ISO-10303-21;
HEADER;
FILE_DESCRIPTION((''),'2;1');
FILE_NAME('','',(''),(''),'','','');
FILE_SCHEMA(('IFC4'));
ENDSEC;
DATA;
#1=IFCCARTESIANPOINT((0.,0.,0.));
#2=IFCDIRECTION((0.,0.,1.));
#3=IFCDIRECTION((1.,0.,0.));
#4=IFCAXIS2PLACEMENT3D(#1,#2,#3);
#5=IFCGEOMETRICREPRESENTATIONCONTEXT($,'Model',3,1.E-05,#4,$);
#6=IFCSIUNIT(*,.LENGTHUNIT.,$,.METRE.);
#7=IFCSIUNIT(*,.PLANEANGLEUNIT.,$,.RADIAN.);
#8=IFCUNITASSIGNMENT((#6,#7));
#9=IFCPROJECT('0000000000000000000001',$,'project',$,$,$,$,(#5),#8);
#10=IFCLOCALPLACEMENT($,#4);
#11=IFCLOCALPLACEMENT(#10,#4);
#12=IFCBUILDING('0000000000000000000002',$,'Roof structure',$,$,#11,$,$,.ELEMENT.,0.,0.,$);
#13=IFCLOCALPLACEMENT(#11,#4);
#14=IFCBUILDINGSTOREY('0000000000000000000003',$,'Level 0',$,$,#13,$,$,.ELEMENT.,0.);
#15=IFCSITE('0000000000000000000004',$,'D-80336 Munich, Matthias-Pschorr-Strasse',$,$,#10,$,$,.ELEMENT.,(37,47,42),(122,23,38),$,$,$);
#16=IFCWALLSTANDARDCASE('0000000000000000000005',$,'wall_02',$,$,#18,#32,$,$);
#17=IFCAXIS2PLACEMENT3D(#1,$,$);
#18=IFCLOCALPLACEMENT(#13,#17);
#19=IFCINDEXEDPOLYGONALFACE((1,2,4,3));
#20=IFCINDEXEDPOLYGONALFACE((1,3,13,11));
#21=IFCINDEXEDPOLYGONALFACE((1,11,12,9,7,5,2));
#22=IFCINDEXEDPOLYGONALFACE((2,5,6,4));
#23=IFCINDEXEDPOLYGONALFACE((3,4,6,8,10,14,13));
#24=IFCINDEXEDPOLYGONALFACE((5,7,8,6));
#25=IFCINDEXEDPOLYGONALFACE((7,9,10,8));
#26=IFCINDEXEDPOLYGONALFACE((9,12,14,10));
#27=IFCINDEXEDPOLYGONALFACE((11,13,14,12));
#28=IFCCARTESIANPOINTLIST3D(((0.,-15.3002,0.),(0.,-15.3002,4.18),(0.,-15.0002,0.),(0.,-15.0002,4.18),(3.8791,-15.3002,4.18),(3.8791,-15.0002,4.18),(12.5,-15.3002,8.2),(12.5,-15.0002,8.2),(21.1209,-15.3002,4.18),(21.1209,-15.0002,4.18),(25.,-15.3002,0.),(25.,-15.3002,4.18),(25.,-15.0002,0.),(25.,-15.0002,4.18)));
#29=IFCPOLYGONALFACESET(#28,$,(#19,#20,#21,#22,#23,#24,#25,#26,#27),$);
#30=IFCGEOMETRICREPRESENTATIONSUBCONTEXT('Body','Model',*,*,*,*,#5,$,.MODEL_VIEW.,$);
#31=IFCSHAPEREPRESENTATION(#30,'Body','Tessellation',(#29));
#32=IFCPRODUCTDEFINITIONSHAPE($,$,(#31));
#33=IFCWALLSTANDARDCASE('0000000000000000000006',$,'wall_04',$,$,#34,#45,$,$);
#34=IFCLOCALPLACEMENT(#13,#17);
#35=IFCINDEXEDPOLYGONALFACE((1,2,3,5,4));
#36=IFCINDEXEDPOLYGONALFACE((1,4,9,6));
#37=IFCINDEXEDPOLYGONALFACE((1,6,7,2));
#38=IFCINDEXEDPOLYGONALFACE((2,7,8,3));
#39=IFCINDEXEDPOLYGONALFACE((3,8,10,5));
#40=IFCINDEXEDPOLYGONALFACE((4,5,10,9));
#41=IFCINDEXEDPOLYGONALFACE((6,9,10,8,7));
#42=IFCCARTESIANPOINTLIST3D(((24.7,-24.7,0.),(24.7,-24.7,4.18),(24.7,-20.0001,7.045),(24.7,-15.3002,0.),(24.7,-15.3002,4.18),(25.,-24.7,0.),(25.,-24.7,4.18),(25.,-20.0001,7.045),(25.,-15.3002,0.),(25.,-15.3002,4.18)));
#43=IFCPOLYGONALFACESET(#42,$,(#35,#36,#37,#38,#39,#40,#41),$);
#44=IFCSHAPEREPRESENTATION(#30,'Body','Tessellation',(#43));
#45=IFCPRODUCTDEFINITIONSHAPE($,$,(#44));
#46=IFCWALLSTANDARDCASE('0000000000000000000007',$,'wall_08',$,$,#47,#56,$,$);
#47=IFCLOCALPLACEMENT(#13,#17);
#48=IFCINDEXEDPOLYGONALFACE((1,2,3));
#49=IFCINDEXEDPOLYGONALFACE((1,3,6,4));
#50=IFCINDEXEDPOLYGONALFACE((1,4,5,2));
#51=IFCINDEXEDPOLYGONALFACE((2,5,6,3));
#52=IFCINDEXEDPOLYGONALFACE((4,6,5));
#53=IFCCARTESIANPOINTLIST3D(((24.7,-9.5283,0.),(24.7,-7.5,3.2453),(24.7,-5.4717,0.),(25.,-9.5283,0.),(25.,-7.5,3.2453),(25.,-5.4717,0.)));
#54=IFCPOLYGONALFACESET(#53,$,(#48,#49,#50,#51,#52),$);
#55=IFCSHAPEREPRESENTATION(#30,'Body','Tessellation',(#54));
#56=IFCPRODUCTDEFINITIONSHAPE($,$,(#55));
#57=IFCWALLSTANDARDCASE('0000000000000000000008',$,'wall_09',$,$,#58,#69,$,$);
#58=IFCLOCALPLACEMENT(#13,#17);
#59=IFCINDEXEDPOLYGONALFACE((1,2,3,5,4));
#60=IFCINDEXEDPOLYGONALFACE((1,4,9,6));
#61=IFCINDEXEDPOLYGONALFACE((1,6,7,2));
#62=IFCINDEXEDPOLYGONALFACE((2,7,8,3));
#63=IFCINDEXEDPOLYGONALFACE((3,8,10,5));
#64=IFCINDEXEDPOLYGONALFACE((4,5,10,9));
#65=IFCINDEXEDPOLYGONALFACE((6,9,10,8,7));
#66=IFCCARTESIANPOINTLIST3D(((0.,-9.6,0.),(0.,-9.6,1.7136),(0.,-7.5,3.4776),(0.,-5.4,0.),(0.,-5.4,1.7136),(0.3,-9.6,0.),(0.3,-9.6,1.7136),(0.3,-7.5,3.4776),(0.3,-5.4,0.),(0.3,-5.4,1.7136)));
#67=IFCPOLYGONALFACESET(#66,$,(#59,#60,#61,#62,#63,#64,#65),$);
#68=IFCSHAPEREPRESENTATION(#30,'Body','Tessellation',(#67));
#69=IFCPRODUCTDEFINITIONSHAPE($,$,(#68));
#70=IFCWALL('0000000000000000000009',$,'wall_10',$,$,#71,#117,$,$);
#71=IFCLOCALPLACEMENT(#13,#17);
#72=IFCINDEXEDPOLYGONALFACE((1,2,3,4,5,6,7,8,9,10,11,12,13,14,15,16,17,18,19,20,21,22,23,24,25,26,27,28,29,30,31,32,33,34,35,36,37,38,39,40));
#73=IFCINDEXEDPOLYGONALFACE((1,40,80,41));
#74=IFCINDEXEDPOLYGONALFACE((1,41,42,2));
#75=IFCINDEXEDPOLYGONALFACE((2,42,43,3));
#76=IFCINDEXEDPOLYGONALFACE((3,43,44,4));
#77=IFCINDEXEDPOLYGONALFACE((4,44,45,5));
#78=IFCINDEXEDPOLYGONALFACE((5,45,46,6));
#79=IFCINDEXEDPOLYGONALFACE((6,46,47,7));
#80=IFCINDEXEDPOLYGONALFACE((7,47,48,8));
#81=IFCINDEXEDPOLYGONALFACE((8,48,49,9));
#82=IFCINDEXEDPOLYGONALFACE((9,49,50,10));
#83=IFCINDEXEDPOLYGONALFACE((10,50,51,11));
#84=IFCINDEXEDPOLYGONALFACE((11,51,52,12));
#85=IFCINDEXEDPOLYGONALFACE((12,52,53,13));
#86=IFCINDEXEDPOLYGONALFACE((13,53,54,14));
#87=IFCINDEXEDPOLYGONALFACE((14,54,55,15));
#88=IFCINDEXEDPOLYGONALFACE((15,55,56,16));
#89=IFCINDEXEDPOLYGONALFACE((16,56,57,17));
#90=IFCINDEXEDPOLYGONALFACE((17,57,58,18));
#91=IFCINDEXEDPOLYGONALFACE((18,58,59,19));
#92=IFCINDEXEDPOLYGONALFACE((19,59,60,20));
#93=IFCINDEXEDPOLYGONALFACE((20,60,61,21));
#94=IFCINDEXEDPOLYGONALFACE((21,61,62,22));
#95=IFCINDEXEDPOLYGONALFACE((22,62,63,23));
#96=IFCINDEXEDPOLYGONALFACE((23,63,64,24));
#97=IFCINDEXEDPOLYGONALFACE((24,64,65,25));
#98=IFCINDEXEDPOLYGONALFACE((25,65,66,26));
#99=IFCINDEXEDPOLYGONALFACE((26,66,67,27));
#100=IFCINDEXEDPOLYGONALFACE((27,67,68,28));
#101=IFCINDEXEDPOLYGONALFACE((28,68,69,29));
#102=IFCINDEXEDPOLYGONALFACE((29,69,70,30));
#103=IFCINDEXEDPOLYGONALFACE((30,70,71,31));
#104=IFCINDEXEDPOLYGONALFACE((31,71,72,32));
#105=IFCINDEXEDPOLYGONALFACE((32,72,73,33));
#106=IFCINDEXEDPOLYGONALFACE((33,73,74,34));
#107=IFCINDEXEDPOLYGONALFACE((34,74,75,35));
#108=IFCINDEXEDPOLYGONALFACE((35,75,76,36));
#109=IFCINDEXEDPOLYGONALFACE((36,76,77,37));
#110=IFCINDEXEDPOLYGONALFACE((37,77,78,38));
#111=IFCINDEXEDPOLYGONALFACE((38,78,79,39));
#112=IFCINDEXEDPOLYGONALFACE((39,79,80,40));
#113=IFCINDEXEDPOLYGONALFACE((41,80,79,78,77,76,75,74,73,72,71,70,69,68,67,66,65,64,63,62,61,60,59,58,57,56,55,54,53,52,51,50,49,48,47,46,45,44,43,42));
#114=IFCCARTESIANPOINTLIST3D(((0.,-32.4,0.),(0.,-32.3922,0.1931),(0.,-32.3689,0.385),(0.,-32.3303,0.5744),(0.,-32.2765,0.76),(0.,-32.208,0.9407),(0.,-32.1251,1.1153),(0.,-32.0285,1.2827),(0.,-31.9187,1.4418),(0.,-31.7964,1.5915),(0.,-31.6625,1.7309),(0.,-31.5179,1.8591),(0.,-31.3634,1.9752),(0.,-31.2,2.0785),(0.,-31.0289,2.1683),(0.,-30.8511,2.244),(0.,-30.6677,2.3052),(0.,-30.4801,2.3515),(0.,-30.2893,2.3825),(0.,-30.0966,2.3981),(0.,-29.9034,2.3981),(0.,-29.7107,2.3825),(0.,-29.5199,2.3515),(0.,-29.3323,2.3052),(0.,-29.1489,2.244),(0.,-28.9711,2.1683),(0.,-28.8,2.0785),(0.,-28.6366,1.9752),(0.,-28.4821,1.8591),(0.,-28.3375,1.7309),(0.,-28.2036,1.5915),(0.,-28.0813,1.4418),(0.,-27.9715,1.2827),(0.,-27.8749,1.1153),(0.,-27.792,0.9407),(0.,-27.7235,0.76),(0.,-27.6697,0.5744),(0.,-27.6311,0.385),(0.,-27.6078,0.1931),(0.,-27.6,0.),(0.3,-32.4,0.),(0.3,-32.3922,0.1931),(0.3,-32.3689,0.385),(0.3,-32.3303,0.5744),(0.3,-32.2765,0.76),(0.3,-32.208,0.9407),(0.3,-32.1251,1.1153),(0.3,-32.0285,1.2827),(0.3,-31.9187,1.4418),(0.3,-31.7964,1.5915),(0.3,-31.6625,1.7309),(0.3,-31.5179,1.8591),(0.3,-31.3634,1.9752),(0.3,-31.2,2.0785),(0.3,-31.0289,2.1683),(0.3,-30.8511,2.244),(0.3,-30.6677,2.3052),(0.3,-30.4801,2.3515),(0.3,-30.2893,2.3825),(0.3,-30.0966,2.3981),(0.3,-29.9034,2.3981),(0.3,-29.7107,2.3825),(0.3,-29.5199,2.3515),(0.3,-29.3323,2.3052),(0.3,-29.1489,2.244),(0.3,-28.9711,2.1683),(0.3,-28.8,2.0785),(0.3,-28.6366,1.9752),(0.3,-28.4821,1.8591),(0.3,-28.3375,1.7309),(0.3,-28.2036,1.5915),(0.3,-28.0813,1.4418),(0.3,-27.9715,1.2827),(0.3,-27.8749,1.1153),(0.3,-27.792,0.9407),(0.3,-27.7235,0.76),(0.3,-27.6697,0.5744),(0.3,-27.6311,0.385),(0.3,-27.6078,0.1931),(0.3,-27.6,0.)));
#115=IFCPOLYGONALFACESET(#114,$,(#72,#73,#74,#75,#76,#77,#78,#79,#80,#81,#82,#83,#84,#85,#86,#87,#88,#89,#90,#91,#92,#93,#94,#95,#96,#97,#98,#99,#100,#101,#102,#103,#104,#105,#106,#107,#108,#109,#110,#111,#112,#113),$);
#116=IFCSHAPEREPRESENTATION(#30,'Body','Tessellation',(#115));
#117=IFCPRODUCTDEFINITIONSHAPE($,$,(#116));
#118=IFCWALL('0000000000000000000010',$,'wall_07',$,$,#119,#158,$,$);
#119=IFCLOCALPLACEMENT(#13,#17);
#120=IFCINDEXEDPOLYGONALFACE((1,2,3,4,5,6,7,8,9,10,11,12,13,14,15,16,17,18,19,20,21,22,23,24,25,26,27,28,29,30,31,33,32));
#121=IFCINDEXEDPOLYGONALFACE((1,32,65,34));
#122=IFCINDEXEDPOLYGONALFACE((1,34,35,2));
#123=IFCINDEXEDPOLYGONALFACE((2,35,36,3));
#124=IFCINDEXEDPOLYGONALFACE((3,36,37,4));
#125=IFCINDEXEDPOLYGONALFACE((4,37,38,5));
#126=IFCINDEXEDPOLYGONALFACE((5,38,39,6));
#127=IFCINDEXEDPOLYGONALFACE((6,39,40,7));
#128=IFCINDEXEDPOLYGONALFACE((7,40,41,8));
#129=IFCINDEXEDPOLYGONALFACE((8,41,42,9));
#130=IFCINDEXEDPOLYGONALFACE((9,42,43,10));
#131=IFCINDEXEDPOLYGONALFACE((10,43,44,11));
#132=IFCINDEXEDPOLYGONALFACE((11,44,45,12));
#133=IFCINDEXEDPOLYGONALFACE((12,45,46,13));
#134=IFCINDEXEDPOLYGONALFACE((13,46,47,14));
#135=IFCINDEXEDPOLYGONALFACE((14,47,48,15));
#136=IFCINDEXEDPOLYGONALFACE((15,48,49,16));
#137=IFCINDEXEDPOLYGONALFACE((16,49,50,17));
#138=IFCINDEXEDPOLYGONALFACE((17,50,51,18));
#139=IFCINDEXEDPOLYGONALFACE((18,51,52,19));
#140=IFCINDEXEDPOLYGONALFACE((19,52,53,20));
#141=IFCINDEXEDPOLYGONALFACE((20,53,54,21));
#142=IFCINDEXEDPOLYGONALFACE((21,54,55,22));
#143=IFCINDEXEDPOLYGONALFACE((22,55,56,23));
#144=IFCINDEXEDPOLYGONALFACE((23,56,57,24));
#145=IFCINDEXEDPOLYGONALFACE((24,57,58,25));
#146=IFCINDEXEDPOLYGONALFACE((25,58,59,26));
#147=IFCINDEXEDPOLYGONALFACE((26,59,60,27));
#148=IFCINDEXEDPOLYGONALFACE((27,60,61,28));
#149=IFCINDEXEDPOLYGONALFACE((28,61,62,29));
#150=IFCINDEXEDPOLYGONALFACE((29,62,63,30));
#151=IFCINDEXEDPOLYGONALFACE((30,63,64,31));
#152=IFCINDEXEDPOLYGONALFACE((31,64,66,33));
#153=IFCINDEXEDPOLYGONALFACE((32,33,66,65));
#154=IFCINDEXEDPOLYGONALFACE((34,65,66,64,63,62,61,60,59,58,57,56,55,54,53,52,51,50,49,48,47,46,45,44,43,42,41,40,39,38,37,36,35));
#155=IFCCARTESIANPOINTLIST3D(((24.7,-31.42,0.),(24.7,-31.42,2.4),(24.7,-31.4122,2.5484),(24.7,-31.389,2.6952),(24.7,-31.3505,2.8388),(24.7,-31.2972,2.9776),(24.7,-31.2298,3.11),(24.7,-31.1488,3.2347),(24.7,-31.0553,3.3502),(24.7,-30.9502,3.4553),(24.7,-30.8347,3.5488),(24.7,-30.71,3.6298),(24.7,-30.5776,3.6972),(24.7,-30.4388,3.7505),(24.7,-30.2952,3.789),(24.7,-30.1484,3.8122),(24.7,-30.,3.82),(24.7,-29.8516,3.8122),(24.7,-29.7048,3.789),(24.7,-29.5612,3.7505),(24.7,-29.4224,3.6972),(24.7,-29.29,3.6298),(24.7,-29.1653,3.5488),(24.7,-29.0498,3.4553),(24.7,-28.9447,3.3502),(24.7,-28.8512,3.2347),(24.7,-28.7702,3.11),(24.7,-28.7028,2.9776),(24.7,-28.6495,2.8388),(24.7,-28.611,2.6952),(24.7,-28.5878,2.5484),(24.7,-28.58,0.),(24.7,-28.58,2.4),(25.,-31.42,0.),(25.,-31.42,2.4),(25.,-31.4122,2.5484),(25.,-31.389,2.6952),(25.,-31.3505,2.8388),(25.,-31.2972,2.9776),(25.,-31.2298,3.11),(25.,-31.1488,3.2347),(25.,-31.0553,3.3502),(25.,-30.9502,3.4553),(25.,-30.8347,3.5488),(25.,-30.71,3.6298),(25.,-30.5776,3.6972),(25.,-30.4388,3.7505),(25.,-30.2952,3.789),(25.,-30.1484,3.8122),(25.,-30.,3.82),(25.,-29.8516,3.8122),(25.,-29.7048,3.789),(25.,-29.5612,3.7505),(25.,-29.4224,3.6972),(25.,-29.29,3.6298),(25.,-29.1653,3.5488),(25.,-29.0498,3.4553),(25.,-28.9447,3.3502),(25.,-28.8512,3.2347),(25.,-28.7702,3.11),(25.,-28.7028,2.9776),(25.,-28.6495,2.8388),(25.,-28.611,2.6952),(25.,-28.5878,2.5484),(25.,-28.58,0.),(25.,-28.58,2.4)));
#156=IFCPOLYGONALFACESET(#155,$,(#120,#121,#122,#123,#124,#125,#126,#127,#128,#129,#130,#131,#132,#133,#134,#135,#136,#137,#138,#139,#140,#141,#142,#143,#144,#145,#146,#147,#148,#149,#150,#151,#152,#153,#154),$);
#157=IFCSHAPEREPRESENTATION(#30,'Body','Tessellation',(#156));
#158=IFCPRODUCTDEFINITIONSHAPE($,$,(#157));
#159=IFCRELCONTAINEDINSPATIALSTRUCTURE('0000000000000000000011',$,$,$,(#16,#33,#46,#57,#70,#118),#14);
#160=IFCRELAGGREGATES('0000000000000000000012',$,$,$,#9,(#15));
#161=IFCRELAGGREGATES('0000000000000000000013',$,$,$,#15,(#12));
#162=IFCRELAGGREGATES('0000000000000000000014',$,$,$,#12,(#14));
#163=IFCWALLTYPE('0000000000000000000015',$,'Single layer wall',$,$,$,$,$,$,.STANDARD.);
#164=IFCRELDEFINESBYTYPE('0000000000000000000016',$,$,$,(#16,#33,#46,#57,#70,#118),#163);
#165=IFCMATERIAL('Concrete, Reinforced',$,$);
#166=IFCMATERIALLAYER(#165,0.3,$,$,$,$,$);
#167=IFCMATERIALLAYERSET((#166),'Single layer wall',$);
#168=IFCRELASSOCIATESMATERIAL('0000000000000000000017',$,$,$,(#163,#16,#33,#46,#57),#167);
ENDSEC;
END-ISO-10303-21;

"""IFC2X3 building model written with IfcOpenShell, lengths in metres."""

from ifc_helpers import new_model, si_unit, point, frame, origin_with_axes, origin_2d_with_axis, place, context, subcontext, project, spatial, polyline, circle_curve, trimmed, segment, composite_curve, outline, extrude, clip, bounded_halfspace, material, layer, layer_set, layer_usage, type_object, element, save


model = new_model("IFC2X3")

# Units and contexts
model_context = context("Model", 3, precision=1e-05, world=origin_with_axes())
body_context = subcontext(model_context, "Body", "Model", "MODEL_VIEW")
ifc_project = project(units=[si_unit("LENGTHUNIT", "METRE"), si_unit("PLANEANGLEUNIT", "RADIAN")], contexts=[model_context])

# Site, building, storey
site_placement = place(None, origin_with_axes())
site = spatial("IfcSite", under=ifc_project, at=site_placement, Name="D-80336 Munich, Matthias-Pschorr-Strasse", CompositionType="ELEMENT", RefLatitude=(37, 47, 42), RefLongitude=(122, 23, 38))
building_placement = place(site_placement, origin_with_axes())
building = spatial("IfcBuilding", under=site, at=building_placement, Name="Roof structure", CompositionType="ELEMENT", ElevationOfRefHeight=0.0, ElevationOfTerrain=0.0)
storey_placement = place(building_placement, origin_with_axes())
storey = spatial("IfcBuildingStorey", under=building, at=storey_placement, Name="Level 0", CompositionType="ELEMENT", Elevation=0.0)

# Walls
ifc_material_1 = material(Name="Concrete, Reinforced")
ifc_layer_1 = layer(ifc_material_1, 0.3)
ifc_layer_set_1 = layer_set([ifc_layer_1], Name="Single layer wall")
ifc_layer_usage_1 = layer_usage(ifc_layer_set_1, "AXIS2", "POSITIVE", 0.0)
wall_type = type_object("IfcWallType", Name="Single layer wall", PredefinedType="STANDARD", material=ifc_layer_set_1)
wall_1_placement = place(storey_placement, frame((0.0, -15.3002, 0.0), z_axis=(0.0, 0.0, 1.0), x_axis=(1.0, 0.0, 0.0)))
element("IfcWallStandardCase", 1, at=wall_1_placement, inside=storey, type_object=wall_type, material=ifc_layer_usage_1, Name="wall_02", context=body_context, shape_type="Clipping", body=[
    clip(clip(clip(clip(extrude(outline(polyline([(12.5, -0.15), (-12.5, -0.15), (-12.5, 0.15), (12.5, 0.15), (12.5, -0.15)])), frame((12.5, 0.15, 0.0), z_axis=(0.0, 0.0, 1.0), x_axis=(1.0, 0.0, 0.0)), (0.0, 0.0, 1.0), 8.2), bounded_halfspace(frame((-0.9082, 15.3002, 1.9477), z_axis=(-0.422618, 0.0, 0.906308), x_axis=(0.0, -1.0, 0.0)), False, frame((12.5, 0.15, 0.0), z_axis=(0.0, 0.0, 1.0), x_axis=(1.0, 0.0, 0.0)), polyline([(-8.6209, -0.15), (0.0, -0.15), (0.0, 0.15), (-8.6209, 0.15), (-8.6209, -0.15)]))), bounded_halfspace(frame((0.0, 15.3002, 4.18), z_axis=(0.0, 0.0, 1.0), x_axis=(1.0, 0.0, 0.0)), False, frame((12.5, 0.15, 0.0), z_axis=(0.0, 0.0, 1.0), x_axis=(1.0, 0.0, 0.0)), polyline([(-12.5, -0.15), (-8.6209, -0.15), (-8.6209, 0.15), (-12.5, 0.15), (-12.5, -0.15)]))), bounded_halfspace(frame((5.3734, 15.3002, 11.5232), z_axis=(0.422618, 0.0, 0.906308), x_axis=(0.0, 1.0, 0.0)), False, frame((12.5, 0.15, 0.0), z_axis=(0.0, 0.0, 1.0), x_axis=(1.0, 0.0, 0.0)), polyline([(0.0, -0.15), (8.6209, -0.15), (8.6209, 0.15), (0.0, 0.15), (0.0, -0.15)]))), bounded_halfspace(frame((0.0, 15.3002, 4.18), z_axis=(0.0, 0.0, 1.0), x_axis=(1.0, 0.0, 0.0)), False, frame((12.5, 0.15, 0.0), z_axis=(0.0, 0.0, 1.0), x_axis=(1.0, 0.0, 0.0)), polyline([(8.6209, -0.15), (12.5, -0.15), (12.5, 0.15), (8.6209, 0.15), (8.6209, -0.15)]))),
])
ifc_layer_usage_2 = layer_usage(ifc_layer_set_1, "AXIS2", "POSITIVE", 0.0)
wall_2_placement = place(storey_placement, frame((24.7, -15.3002, 0.0), z_axis=(0.0, 0.0, 1.0), x_axis=(0.0, -1.0, 0.0)))
element("IfcWallStandardCase", 2, at=wall_2_placement, inside=storey, type_object=wall_type, material=ifc_layer_usage_2, Name="wall_04", context=body_context, shape_type="Clipping", body=[
    clip(clip(extrude(outline(polyline([(4.6999, -0.15), (-4.6999, -0.15), (-4.6999, 0.15), (4.6999, 0.15), (4.6999, -0.15)])), frame((4.6999, 0.15, 0.0), z_axis=(0.0, 0.0, 1.0), x_axis=(1.0, 0.0, 0.0)), (0.0, 0.0, 1.0), 7.045), bounded_halfspace(frame((-13.0128, -24.7, -3.7524), z_axis=(-0.520502, 0.0, 0.853861), x_axis=(0.0, -1.0, 0.0)), False, frame((4.6999, 0.15, 0.0), z_axis=(0.0, 0.0, 1.0), x_axis=(1.0, 0.0, 0.0)), polyline([(-4.6999, -0.15), (0.0, -0.15), (0.0, 0.15), (-4.6999, 0.15), (-4.6999, -0.15)]))), bounded_halfspace(frame((-6.7507, -24.7, 14.0251), z_axis=(0.520502, 0.0, 0.853861), x_axis=(0.0, 1.0, 0.0)), False, frame((4.6999, 0.15, 0.0), z_axis=(0.0, 0.0, 1.0), x_axis=(1.0, 0.0, 0.0)), polyline([(0.0, -0.15), (4.6999, -0.15), (4.6999, 0.15), (0.0, 0.15), (0.0, -0.15)]))),
])
ifc_layer_usage_3 = layer_usage(ifc_layer_set_1, "AXIS2", "POSITIVE", 0.0)
wall_3_placement = place(storey_placement, frame((24.7, -5.4717, 0.0), z_axis=(0.0, 0.0, 1.0), x_axis=(0.0, -1.0, 0.0)))
element("IfcWallStandardCase", 3, at=wall_3_placement, inside=storey, type_object=wall_type, material=ifc_layer_usage_3, Name="wall_08", context=body_context, shape_type="Clipping", body=[
    clip(clip(extrude(outline(polyline([(2.0283, -0.15), (-2.0283, -0.15), (-2.0283, 0.15), (2.0283, 0.15), (2.0283, -0.15)])), frame((2.0283, 0.15, 0.0), z_axis=(0.0, 0.0, 1.0), x_axis=(1.0, 0.0, 0.0)), (0.0, 0.0, 1.0), 3.2453), bounded_halfspace(frame((-1.537, -24.7, -2.4592), z_axis=(-0.847998, 0.0, 0.529999), x_axis=(0.0, -1.0, 0.0)), False, frame((2.0283, 0.15, 0.0), z_axis=(0.0, 0.0, 1.0), x_axis=(1.0, 0.0, 0.0)), polyline([(-2.0283, -0.15), (0.0, -0.15), (0.0, 0.15), (-2.0283, 0.15), (-2.0283, -0.15)]))), bounded_halfspace(frame((1.3801, -24.7, 4.2824), z_axis=(0.847998, 0.0, 0.529999), x_axis=(0.0, 1.0, 0.0)), False, frame((2.0283, 0.15, 0.0), z_axis=(0.0, 0.0, 1.0), x_axis=(1.0, 0.0, 0.0)), polyline([(0.0, -0.15), (2.0283, -0.15), (2.0283, 0.15), (0.0, 0.15), (0.0, -0.15)]))),
])
ifc_layer_usage_4 = layer_usage(ifc_layer_set_1, "AXIS2", "POSITIVE", 0.0)
wall_4_placement = place(storey_placement, frame((0.0, -5.4, 0.0), z_axis=(0.0, 0.0, 1.0), x_axis=(0.0, -1.0, 0.0)))
element("IfcWallStandardCase", 4, at=wall_4_placement, inside=storey, type_object=wall_type, material=ifc_layer_usage_4, Name="wall_09", context=body_context, shape_type="Clipping", body=[
    clip(clip(extrude(outline(polyline([(-2.1, 0.15), (2.1, 0.15), (2.1, -0.15), (-2.1, -0.15), (-2.1, 0.15)])), frame((2.1, 0.15, 0.0), z_axis=(0.0, 0.0, 1.0), x_axis=(1.0, 0.0, 0.0)), (0.0, 0.0, 1.0), 3.4776), bounded_halfspace(frame((-0.5846, 0.0, 5.7326), z_axis=(0.643192, 0.0, 0.765705), x_axis=(0.0, 1.0, 0.0)), False, frame((2.1, 0.15, 0.0), z_axis=(0.0, 0.0, 1.0), x_axis=(1.0, 0.0, 0.0)), polyline([(2.1, 0.15), (0.0, 0.15), (0.0, -0.15), (2.1, -0.15), (2.1, 0.15)]))), bounded_halfspace(frame((-4.01, 0.0, -1.6548), z_axis=(-0.643192, 0.0, 0.765705), x_axis=(0.0, -1.0, 0.0)), False, frame((2.1, 0.15, 0.0), z_axis=(0.0, 0.0, 1.0), x_axis=(1.0, 0.0, 0.0)), polyline([(0.0, 0.15), (-2.1, 0.15), (-2.1, -0.15), (0.0, -0.15), (0.0, 0.15)]))),
])
wall_5_placement = place(storey_placement, origin_with_axes())
element("IfcWall", 5, at=wall_5_placement, inside=storey, type_object=wall_type, Name="wall_10", context=body_context, shape_type="SweptSolid", body=[
    extrude(outline(composite_curve([segment(polyline([(0.0, -2.4), (0.0, 2.4)]), True, "CONTINUOUS"), segment(trimmed(circle_curve(origin_2d_with_axis(), 2.4), [point((0.0, 2.4))], [point((0.0, -2.4))], False, "CARTESIAN"), True, "CONTINUOUS")], self_intersect=False)), frame((0.0, -30.0, 0.0), z_axis=(1.0, 0.0, 0.0), x_axis=(0.0, 0.0, 1.0)), (0.0, 0.0, 1.0), 0.3),
])
wall_6_placement = place(storey_placement, origin_with_axes())
element("IfcWall", 6, at=wall_6_placement, inside=storey, type_object=wall_type, Name="wall_07", context=body_context, shape_type="SweptSolid", body=[
    extrude(outline(composite_curve([segment(trimmed(circle_curve(origin_2d_with_axis(), 1.42), [point((0.0, 1.42))], [point((0.0, -1.42))], False, "CARTESIAN"), True, "CONTINUOUS"), segment(polyline([(0.0, -1.42), (-2.4, -1.42)]), True, "CONTINUOUS"), segment(polyline([(-2.4, -1.42), (-2.4, 1.42)]), True, "CONTINUOUS"), segment(polyline([(-2.4, 1.42), (0.0, 1.42)]), True, "CONTINUOUS")], self_intersect=False)), frame((24.7, -30.0, 2.4), z_axis=(1.0, 0.0, 0.0), x_axis=(0.0, 0.0, 1.0)), (0.0, 0.0, 1.0), 0.3),
])

save(model, "model.ifc")
